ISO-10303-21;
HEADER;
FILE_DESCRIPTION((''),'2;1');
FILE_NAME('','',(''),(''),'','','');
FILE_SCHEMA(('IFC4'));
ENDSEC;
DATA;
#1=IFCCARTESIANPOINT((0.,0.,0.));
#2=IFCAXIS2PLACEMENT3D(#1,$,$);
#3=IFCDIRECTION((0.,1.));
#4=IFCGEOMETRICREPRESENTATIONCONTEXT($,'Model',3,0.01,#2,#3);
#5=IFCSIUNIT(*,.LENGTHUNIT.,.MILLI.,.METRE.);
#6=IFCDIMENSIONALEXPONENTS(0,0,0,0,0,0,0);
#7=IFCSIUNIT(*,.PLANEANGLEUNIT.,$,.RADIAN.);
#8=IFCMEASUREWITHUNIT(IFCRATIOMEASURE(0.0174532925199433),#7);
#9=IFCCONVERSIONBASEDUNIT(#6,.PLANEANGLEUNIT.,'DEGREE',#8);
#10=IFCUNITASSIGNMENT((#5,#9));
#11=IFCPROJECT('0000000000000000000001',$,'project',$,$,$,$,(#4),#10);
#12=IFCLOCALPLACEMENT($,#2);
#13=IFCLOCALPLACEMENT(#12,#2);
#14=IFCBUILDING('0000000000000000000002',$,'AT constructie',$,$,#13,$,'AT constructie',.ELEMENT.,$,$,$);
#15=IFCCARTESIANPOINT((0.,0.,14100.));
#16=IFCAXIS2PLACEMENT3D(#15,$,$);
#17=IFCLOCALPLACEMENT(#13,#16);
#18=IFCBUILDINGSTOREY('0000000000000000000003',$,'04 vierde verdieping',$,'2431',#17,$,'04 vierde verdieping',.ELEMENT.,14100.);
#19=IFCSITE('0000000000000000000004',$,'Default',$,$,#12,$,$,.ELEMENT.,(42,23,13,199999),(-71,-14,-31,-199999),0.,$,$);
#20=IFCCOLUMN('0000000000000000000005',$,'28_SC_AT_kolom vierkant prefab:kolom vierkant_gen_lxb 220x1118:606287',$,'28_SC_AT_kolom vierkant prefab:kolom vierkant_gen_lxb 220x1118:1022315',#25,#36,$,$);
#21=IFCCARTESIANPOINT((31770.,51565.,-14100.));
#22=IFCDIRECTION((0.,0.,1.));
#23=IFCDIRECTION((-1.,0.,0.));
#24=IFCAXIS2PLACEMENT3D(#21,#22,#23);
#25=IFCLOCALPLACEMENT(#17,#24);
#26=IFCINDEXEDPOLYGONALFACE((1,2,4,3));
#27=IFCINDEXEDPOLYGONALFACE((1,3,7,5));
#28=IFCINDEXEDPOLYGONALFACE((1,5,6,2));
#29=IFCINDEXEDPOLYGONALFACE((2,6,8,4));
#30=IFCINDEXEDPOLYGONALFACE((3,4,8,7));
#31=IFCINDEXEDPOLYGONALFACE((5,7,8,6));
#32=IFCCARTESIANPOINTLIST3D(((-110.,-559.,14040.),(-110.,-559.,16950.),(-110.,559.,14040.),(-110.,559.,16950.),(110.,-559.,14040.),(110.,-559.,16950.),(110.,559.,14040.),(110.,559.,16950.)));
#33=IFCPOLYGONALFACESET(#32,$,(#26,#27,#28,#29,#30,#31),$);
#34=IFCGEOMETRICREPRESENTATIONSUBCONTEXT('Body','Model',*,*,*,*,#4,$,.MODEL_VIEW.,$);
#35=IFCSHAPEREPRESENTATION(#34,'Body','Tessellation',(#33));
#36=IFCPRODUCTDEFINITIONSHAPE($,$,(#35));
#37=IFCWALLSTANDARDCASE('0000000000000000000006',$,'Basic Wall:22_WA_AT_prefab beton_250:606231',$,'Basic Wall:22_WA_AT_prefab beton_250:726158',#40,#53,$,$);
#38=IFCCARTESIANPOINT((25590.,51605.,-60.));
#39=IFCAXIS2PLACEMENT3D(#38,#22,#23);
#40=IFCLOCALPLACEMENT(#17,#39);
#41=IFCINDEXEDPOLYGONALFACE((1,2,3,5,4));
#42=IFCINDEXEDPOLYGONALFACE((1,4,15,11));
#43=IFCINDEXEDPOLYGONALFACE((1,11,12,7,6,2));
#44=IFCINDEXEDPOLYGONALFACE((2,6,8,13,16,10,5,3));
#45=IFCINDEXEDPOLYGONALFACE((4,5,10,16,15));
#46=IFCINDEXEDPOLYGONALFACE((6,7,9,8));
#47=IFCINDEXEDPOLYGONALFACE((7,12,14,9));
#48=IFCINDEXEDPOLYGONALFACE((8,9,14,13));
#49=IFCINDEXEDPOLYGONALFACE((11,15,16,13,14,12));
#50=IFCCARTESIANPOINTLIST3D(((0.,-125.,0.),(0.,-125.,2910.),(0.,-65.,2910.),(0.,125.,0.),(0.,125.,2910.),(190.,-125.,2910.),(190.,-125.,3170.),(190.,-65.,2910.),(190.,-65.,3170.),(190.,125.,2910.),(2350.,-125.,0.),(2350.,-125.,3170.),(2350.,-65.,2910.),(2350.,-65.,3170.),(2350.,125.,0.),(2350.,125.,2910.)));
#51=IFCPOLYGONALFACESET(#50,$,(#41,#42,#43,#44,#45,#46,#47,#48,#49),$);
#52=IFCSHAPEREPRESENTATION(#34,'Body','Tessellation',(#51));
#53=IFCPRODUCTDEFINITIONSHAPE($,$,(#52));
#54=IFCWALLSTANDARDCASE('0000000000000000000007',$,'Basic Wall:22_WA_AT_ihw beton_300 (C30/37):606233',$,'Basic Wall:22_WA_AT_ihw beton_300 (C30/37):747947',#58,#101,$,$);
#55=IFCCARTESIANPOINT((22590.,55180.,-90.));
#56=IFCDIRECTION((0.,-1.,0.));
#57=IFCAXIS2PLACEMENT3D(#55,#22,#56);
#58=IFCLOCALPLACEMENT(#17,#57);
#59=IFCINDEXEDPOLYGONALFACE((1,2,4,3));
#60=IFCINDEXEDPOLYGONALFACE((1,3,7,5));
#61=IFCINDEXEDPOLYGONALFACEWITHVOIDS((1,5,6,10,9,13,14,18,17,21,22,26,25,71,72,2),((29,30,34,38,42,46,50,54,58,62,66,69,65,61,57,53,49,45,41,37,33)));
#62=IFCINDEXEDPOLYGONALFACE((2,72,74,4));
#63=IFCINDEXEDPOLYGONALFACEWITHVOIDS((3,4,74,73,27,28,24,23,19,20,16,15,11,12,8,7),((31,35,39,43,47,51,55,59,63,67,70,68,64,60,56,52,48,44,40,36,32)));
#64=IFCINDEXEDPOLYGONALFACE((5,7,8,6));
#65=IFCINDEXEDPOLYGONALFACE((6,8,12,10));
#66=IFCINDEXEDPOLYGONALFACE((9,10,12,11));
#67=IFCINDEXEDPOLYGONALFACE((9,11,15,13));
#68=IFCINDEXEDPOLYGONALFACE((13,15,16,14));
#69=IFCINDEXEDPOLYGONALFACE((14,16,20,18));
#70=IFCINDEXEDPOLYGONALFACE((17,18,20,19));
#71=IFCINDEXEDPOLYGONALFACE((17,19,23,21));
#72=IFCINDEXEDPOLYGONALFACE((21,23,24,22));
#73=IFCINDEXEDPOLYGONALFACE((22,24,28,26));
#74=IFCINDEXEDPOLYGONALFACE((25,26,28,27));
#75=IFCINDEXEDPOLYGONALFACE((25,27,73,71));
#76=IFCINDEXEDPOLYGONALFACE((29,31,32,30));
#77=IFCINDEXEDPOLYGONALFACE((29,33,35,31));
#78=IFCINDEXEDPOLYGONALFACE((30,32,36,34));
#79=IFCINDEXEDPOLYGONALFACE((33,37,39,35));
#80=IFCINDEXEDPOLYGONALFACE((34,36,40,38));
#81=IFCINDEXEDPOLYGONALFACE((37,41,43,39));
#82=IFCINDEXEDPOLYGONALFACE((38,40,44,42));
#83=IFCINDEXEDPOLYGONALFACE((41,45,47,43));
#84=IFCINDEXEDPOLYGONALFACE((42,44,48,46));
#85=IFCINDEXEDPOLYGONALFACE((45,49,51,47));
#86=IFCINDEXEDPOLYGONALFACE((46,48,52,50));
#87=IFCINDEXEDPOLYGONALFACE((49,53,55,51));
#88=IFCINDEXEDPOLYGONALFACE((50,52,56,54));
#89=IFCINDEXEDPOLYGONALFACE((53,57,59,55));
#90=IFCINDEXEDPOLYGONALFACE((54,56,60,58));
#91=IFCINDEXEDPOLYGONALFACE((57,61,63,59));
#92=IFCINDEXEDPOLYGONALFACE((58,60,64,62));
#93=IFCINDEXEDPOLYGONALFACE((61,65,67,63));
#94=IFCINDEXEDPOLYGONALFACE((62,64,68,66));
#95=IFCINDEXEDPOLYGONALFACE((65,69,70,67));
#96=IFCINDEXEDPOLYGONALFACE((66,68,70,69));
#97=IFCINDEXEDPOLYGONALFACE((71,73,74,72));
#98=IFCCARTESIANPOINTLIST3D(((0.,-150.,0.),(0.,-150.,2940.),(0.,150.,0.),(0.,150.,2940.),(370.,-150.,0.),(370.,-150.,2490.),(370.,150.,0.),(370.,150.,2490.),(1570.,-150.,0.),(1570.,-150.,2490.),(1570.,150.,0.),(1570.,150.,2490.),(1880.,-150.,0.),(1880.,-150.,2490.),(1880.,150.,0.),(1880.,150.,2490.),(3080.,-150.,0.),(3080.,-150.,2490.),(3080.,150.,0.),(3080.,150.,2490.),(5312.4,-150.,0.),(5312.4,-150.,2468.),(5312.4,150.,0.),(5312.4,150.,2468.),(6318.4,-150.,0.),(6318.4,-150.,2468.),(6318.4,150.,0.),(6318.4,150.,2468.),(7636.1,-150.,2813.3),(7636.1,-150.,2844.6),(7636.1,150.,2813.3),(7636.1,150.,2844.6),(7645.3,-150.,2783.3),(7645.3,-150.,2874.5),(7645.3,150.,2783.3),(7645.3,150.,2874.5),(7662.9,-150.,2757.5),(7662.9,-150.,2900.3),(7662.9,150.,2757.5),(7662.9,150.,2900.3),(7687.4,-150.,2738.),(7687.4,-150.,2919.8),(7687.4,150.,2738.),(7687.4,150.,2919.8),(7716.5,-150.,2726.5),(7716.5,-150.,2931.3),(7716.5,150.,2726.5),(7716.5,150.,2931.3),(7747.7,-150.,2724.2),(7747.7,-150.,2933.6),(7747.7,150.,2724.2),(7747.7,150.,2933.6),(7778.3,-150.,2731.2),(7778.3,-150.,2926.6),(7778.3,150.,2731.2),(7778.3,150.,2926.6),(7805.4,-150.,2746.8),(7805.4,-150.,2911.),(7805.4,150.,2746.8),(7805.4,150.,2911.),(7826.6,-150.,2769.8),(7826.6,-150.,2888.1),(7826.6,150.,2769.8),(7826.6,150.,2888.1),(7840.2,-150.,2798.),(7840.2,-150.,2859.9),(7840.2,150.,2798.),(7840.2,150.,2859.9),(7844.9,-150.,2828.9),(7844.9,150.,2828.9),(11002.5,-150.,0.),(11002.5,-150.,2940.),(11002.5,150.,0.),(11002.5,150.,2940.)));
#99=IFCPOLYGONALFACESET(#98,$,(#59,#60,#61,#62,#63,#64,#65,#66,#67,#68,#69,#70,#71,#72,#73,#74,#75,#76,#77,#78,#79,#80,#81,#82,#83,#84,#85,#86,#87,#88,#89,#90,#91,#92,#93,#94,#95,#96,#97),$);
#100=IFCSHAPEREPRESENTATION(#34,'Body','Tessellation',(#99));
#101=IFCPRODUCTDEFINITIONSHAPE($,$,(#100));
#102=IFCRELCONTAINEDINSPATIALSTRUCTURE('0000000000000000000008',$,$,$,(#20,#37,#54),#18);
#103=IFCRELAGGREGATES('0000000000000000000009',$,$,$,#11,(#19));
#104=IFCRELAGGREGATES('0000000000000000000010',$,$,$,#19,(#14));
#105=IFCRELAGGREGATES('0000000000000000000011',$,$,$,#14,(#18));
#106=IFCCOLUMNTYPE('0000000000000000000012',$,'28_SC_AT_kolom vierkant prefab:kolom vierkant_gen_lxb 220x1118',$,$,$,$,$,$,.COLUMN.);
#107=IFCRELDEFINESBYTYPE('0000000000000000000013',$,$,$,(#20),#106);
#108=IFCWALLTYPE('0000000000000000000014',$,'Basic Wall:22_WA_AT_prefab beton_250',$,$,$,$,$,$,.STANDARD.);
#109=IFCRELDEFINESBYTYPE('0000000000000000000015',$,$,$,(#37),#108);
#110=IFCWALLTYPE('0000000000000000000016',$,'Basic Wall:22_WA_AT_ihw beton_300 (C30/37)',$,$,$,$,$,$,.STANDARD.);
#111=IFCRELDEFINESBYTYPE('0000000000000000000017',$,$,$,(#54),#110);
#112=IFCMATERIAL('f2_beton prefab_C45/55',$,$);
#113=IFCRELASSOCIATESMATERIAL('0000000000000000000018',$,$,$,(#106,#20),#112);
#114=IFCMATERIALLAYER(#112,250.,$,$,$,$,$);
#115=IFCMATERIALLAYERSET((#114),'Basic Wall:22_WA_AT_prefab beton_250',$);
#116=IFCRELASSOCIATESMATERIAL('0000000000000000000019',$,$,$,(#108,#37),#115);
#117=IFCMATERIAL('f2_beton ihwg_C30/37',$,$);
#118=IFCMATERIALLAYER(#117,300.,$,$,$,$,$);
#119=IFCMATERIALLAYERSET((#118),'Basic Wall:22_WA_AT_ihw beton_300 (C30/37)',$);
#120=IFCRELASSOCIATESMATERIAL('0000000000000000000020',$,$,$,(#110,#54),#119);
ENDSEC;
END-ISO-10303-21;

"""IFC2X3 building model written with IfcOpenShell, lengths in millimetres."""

from ifc_helpers import new_model, entity, si_unit, converted_unit, direction, frame, frame_2d, origin, origin_2d_with_axis, place, context, subcontext, project, spatial, rectangle, circle, extrude, source, transform, mapped, material, layer, layer_set, layer_usage, type_object, type_shapes, element, save


model = new_model("IFC2X3")

# Units and contexts
model_context = context("Model", 3, precision=0.01, world=origin(), true_north=direction((0.0, 1.0)))
body_context = subcontext(model_context, "Body", "Model", "MODEL_VIEW")
ifc_project = project(units=[si_unit("LENGTHUNIT", "METRE", prefix="MILLI"), converted_unit("PLANEANGLEUNIT", "DEGREE", entity("IfcRatioMeasure", 0.0174532925199433), si_unit("PLANEANGLEUNIT", "RADIAN"), dimensions=[0, 0, 0, 0, 0, 0, 0])], contexts=[model_context])

# Site, building, storey
site_placement = place(None, origin())
site = spatial("IfcSite", under=ifc_project, at=site_placement, Name="Default", CompositionType="ELEMENT", RefLatitude=(42, 23, 13, 199999), RefLongitude=(-71, -14, -31, -199999), RefElevation=0.0)
building_placement = place(site_placement, origin())
building = spatial("IfcBuilding", under=site, at=building_placement, Name="AT constructie", LongName="AT constructie", CompositionType="ELEMENT")
storey_placement = place(building_placement, frame((0.0, 0.0, 14100.0)))
storey = spatial("IfcBuildingStorey", under=building, at=storey_placement, Name="04 vierde verdieping", ObjectType="2431", LongName="04 vierde verdieping", CompositionType="ELEMENT", Elevation=14100.0)

# Column
ifc_material_1 = material(Name="f2_beton prefab_C45/55")
column_type = type_object("IfcColumnType", Name="28_SC_AT_kolom vierkant prefab:kolom vierkant_gen_lxb 220x1118", PredefinedType="COLUMN", material=ifc_material_1)
shared_shape = source(origin(), body_context, "Body", "SweptSolid", [
    extrude(rectangle(XDim=220.0, YDim=1118.0, at=origin_2d_with_axis()), frame((0.0, 0.0, 14040.0), z_axis=(0.0, 0.0, 1.0), x_axis=(-1.0, 0.0, 0.0)), (0.0, 0.0, 1.0), 2910.0),
])
type_shapes(column_type, [shared_shape])
column_placement = place(storey_placement, frame((31770.0, 51565.0, -14100.0), z_axis=(0.0, 0.0, 1.0), x_axis=(-1.0, 0.0, 0.0)))
element("IfcColumn", 1, at=column_placement, inside=storey, type_object=column_type, material=ifc_material_1, Name="28_SC_AT_kolom vierkant prefab:kolom vierkant_gen_lxb 220x1118:606287", ObjectType="28_SC_AT_kolom vierkant prefab:kolom vierkant_gen_lxb 220x1118:1022315", context=body_context, shape_type="MappedRepresentation", body=[
    mapped(shared_shape, transform((0.0, 0.0, 0.0), scale=1.0)),
])

# Wall, openings
ifc_layer_1 = layer(ifc_material_1, 250.0)
ifc_layer_set_1 = layer_set([ifc_layer_1], Name="Basic Wall:22_WA_AT_prefab beton_250")
wall_type_1 = type_object("IfcWallType", Name="Basic Wall:22_WA_AT_prefab beton_250", PredefinedType="STANDARD", material=ifc_layer_set_1)
ifc_layer_usage_1 = layer_usage(ifc_layer_set_1, "AXIS2", "NEGATIVE", 125.0)
wall_1_placement = place(storey_placement, frame((25590.0, 51605.0, -60.0), z_axis=(0.0, 0.0, 1.0), x_axis=(-1.0, 0.0, 0.0)))
wall_1 = element("IfcWallStandardCase", 2, at=wall_1_placement, inside=storey, type_object=wall_type_1, material=ifc_layer_usage_1, Name="Basic Wall:22_WA_AT_prefab beton_250:606231", ObjectType="Basic Wall:22_WA_AT_prefab beton_250:726158", context=body_context, shape_type="SweptSolid", body=[
    extrude(rectangle(XDim=2350.0, YDim=250.0, at=frame_2d((1175.0, 0.0), x_axis=(-1.0, 0.0))), origin(), (0.0, 0.0, 1.0), 3170.0),
])
opening_1_placement = place(wall_1_placement, origin())
element("IfcOpeningElement", 3, at=opening_1_placement, cuts=wall_1, ObjectType="Opening", context=body_context, shape_type="SweptSolid", body=[
    extrude(rectangle(XDim=260.0, YDim=190.0, at=frame_2d((0.0, 0.0), x_axis=(0.0, 1.0))), frame((95.0, -3775.0, 3040.0), z_axis=(0.0, 1.0, 0.0), x_axis=(1.0, 0.0, 0.0)), (0.0, 0.0, 1.0), 3900.0),
])
opening_2_placement = place(wall_1_placement, origin())
element("IfcOpeningElement", 4, at=opening_2_placement, cuts=wall_1, ObjectType="Recess", context=body_context, shape_type="SweptSolid", body=[
    extrude(rectangle(XDim=260.0, YDim=2359.0, at=frame_2d((0.0, 0.0), x_axis=(1.0, 0.0))), frame((1170.5, -65.0, 3040.0), z_axis=(0.0, 1.0, 0.0), x_axis=(0.0, 0.0, -1.0)), (0.0, 0.0, 1.0), 190.0),
])

# Shared definitions
ifc_material_2 = material(Name="f2_beton ihwg_C30/37")

# Wall, openings
ifc_layer_2 = layer(ifc_material_2, 300.0)
ifc_layer_set_2 = layer_set([ifc_layer_2], Name="Basic Wall:22_WA_AT_ihw beton_300 (C30/37)")
ifc_layer_usage_2 = layer_usage(ifc_layer_set_2, "AXIS2", "POSITIVE", -150.0)
wall_type_2 = type_object("IfcWallType", Name="Basic Wall:22_WA_AT_ihw beton_300 (C30/37)", PredefinedType="STANDARD", material=ifc_layer_set_2)
wall_2_placement = place(storey_placement, frame((22590.0, 55180.0, -90.0), z_axis=(0.0, 0.0, 1.0), x_axis=(0.0, -1.0, 0.0)))
wall_2 = element("IfcWallStandardCase", 5, at=wall_2_placement, inside=storey, type_object=wall_type_2, material=ifc_layer_usage_2, Name="Basic Wall:22_WA_AT_ihw beton_300 (C30/37):606233", ObjectType="Basic Wall:22_WA_AT_ihw beton_300 (C30/37):747947", context=body_context, shape_type="SweptSolid", body=[
    extrude(rectangle(XDim=11002.5, YDim=300.0, at=frame_2d((5501.2, 0.0), x_axis=(-1.0, 0.0))), origin(), (0.0, 0.0, 1.0), 2940.0),
])
opening_3_placement = place(wall_2_placement, origin())
element("IfcOpeningElement", 6, at=opening_3_placement, cuts=wall_2, ObjectType="Opening", context=body_context, shape_type="SweptSolid", body=[
    extrude(rectangle(XDim=2490.0, YDim=1200.0, at=frame_2d((0.0, 0.0), x_axis=(1.0, 0.0))), frame((970.0, -1374.0, 1245.0), z_axis=(0.0, 1.0, 0.0), x_axis=(0.0, 0.0, -1.0)), (0.0, 0.0, 1.0), 3048.0),
])
opening_4_placement = place(wall_2_placement, origin())
element("IfcOpeningElement", 7, at=opening_4_placement, cuts=wall_2, ObjectType="Opening", context=body_context, shape_type="SweptSolid", body=[
    extrude(rectangle(XDim=2490.0, YDim=1200.0, at=frame_2d((0.0, 0.0), x_axis=(1.0, 0.0))), frame((2480.0, -1374.0, 1245.0), z_axis=(0.0, 1.0, 0.0), x_axis=(0.0, 0.0, -1.0)), (0.0, 0.0, 1.0), 3048.0),
])
opening_5_placement = place(wall_2_placement, origin())
element("IfcOpeningElement", 8, at=opening_5_placement, cuts=wall_2, ObjectType="Opening", context=body_context, shape_type="SweptSolid", body=[
    extrude(rectangle(XDim=2468.0, YDim=1006.0, at=frame_2d((0.0, 0.0), x_axis=(1.0, 0.0))), frame((5815.4, -1374.0, 1234.0), z_axis=(0.0, 1.0, 0.0), x_axis=(0.0, 0.0, -1.0)), (0.0, 0.0, 1.0), 3048.0),
])
opening_6_placement = place(wall_2_placement, origin())
element("IfcOpeningElement", 9, at=opening_6_placement, cuts=wall_2, ObjectType="Opening", context=body_context, shape_type="SweptSolid", body=[
    extrude(circle(Radius=105.0, at=origin_2d_with_axis()), frame((7739.9, -150.0, 2828.9), z_axis=(0.0, 1.0, 0.0), x_axis=(1.0, 0.0, 0.0)), (0.0, 0.0, 1.0), 300.0),
])

save(model, "model.ifc")
